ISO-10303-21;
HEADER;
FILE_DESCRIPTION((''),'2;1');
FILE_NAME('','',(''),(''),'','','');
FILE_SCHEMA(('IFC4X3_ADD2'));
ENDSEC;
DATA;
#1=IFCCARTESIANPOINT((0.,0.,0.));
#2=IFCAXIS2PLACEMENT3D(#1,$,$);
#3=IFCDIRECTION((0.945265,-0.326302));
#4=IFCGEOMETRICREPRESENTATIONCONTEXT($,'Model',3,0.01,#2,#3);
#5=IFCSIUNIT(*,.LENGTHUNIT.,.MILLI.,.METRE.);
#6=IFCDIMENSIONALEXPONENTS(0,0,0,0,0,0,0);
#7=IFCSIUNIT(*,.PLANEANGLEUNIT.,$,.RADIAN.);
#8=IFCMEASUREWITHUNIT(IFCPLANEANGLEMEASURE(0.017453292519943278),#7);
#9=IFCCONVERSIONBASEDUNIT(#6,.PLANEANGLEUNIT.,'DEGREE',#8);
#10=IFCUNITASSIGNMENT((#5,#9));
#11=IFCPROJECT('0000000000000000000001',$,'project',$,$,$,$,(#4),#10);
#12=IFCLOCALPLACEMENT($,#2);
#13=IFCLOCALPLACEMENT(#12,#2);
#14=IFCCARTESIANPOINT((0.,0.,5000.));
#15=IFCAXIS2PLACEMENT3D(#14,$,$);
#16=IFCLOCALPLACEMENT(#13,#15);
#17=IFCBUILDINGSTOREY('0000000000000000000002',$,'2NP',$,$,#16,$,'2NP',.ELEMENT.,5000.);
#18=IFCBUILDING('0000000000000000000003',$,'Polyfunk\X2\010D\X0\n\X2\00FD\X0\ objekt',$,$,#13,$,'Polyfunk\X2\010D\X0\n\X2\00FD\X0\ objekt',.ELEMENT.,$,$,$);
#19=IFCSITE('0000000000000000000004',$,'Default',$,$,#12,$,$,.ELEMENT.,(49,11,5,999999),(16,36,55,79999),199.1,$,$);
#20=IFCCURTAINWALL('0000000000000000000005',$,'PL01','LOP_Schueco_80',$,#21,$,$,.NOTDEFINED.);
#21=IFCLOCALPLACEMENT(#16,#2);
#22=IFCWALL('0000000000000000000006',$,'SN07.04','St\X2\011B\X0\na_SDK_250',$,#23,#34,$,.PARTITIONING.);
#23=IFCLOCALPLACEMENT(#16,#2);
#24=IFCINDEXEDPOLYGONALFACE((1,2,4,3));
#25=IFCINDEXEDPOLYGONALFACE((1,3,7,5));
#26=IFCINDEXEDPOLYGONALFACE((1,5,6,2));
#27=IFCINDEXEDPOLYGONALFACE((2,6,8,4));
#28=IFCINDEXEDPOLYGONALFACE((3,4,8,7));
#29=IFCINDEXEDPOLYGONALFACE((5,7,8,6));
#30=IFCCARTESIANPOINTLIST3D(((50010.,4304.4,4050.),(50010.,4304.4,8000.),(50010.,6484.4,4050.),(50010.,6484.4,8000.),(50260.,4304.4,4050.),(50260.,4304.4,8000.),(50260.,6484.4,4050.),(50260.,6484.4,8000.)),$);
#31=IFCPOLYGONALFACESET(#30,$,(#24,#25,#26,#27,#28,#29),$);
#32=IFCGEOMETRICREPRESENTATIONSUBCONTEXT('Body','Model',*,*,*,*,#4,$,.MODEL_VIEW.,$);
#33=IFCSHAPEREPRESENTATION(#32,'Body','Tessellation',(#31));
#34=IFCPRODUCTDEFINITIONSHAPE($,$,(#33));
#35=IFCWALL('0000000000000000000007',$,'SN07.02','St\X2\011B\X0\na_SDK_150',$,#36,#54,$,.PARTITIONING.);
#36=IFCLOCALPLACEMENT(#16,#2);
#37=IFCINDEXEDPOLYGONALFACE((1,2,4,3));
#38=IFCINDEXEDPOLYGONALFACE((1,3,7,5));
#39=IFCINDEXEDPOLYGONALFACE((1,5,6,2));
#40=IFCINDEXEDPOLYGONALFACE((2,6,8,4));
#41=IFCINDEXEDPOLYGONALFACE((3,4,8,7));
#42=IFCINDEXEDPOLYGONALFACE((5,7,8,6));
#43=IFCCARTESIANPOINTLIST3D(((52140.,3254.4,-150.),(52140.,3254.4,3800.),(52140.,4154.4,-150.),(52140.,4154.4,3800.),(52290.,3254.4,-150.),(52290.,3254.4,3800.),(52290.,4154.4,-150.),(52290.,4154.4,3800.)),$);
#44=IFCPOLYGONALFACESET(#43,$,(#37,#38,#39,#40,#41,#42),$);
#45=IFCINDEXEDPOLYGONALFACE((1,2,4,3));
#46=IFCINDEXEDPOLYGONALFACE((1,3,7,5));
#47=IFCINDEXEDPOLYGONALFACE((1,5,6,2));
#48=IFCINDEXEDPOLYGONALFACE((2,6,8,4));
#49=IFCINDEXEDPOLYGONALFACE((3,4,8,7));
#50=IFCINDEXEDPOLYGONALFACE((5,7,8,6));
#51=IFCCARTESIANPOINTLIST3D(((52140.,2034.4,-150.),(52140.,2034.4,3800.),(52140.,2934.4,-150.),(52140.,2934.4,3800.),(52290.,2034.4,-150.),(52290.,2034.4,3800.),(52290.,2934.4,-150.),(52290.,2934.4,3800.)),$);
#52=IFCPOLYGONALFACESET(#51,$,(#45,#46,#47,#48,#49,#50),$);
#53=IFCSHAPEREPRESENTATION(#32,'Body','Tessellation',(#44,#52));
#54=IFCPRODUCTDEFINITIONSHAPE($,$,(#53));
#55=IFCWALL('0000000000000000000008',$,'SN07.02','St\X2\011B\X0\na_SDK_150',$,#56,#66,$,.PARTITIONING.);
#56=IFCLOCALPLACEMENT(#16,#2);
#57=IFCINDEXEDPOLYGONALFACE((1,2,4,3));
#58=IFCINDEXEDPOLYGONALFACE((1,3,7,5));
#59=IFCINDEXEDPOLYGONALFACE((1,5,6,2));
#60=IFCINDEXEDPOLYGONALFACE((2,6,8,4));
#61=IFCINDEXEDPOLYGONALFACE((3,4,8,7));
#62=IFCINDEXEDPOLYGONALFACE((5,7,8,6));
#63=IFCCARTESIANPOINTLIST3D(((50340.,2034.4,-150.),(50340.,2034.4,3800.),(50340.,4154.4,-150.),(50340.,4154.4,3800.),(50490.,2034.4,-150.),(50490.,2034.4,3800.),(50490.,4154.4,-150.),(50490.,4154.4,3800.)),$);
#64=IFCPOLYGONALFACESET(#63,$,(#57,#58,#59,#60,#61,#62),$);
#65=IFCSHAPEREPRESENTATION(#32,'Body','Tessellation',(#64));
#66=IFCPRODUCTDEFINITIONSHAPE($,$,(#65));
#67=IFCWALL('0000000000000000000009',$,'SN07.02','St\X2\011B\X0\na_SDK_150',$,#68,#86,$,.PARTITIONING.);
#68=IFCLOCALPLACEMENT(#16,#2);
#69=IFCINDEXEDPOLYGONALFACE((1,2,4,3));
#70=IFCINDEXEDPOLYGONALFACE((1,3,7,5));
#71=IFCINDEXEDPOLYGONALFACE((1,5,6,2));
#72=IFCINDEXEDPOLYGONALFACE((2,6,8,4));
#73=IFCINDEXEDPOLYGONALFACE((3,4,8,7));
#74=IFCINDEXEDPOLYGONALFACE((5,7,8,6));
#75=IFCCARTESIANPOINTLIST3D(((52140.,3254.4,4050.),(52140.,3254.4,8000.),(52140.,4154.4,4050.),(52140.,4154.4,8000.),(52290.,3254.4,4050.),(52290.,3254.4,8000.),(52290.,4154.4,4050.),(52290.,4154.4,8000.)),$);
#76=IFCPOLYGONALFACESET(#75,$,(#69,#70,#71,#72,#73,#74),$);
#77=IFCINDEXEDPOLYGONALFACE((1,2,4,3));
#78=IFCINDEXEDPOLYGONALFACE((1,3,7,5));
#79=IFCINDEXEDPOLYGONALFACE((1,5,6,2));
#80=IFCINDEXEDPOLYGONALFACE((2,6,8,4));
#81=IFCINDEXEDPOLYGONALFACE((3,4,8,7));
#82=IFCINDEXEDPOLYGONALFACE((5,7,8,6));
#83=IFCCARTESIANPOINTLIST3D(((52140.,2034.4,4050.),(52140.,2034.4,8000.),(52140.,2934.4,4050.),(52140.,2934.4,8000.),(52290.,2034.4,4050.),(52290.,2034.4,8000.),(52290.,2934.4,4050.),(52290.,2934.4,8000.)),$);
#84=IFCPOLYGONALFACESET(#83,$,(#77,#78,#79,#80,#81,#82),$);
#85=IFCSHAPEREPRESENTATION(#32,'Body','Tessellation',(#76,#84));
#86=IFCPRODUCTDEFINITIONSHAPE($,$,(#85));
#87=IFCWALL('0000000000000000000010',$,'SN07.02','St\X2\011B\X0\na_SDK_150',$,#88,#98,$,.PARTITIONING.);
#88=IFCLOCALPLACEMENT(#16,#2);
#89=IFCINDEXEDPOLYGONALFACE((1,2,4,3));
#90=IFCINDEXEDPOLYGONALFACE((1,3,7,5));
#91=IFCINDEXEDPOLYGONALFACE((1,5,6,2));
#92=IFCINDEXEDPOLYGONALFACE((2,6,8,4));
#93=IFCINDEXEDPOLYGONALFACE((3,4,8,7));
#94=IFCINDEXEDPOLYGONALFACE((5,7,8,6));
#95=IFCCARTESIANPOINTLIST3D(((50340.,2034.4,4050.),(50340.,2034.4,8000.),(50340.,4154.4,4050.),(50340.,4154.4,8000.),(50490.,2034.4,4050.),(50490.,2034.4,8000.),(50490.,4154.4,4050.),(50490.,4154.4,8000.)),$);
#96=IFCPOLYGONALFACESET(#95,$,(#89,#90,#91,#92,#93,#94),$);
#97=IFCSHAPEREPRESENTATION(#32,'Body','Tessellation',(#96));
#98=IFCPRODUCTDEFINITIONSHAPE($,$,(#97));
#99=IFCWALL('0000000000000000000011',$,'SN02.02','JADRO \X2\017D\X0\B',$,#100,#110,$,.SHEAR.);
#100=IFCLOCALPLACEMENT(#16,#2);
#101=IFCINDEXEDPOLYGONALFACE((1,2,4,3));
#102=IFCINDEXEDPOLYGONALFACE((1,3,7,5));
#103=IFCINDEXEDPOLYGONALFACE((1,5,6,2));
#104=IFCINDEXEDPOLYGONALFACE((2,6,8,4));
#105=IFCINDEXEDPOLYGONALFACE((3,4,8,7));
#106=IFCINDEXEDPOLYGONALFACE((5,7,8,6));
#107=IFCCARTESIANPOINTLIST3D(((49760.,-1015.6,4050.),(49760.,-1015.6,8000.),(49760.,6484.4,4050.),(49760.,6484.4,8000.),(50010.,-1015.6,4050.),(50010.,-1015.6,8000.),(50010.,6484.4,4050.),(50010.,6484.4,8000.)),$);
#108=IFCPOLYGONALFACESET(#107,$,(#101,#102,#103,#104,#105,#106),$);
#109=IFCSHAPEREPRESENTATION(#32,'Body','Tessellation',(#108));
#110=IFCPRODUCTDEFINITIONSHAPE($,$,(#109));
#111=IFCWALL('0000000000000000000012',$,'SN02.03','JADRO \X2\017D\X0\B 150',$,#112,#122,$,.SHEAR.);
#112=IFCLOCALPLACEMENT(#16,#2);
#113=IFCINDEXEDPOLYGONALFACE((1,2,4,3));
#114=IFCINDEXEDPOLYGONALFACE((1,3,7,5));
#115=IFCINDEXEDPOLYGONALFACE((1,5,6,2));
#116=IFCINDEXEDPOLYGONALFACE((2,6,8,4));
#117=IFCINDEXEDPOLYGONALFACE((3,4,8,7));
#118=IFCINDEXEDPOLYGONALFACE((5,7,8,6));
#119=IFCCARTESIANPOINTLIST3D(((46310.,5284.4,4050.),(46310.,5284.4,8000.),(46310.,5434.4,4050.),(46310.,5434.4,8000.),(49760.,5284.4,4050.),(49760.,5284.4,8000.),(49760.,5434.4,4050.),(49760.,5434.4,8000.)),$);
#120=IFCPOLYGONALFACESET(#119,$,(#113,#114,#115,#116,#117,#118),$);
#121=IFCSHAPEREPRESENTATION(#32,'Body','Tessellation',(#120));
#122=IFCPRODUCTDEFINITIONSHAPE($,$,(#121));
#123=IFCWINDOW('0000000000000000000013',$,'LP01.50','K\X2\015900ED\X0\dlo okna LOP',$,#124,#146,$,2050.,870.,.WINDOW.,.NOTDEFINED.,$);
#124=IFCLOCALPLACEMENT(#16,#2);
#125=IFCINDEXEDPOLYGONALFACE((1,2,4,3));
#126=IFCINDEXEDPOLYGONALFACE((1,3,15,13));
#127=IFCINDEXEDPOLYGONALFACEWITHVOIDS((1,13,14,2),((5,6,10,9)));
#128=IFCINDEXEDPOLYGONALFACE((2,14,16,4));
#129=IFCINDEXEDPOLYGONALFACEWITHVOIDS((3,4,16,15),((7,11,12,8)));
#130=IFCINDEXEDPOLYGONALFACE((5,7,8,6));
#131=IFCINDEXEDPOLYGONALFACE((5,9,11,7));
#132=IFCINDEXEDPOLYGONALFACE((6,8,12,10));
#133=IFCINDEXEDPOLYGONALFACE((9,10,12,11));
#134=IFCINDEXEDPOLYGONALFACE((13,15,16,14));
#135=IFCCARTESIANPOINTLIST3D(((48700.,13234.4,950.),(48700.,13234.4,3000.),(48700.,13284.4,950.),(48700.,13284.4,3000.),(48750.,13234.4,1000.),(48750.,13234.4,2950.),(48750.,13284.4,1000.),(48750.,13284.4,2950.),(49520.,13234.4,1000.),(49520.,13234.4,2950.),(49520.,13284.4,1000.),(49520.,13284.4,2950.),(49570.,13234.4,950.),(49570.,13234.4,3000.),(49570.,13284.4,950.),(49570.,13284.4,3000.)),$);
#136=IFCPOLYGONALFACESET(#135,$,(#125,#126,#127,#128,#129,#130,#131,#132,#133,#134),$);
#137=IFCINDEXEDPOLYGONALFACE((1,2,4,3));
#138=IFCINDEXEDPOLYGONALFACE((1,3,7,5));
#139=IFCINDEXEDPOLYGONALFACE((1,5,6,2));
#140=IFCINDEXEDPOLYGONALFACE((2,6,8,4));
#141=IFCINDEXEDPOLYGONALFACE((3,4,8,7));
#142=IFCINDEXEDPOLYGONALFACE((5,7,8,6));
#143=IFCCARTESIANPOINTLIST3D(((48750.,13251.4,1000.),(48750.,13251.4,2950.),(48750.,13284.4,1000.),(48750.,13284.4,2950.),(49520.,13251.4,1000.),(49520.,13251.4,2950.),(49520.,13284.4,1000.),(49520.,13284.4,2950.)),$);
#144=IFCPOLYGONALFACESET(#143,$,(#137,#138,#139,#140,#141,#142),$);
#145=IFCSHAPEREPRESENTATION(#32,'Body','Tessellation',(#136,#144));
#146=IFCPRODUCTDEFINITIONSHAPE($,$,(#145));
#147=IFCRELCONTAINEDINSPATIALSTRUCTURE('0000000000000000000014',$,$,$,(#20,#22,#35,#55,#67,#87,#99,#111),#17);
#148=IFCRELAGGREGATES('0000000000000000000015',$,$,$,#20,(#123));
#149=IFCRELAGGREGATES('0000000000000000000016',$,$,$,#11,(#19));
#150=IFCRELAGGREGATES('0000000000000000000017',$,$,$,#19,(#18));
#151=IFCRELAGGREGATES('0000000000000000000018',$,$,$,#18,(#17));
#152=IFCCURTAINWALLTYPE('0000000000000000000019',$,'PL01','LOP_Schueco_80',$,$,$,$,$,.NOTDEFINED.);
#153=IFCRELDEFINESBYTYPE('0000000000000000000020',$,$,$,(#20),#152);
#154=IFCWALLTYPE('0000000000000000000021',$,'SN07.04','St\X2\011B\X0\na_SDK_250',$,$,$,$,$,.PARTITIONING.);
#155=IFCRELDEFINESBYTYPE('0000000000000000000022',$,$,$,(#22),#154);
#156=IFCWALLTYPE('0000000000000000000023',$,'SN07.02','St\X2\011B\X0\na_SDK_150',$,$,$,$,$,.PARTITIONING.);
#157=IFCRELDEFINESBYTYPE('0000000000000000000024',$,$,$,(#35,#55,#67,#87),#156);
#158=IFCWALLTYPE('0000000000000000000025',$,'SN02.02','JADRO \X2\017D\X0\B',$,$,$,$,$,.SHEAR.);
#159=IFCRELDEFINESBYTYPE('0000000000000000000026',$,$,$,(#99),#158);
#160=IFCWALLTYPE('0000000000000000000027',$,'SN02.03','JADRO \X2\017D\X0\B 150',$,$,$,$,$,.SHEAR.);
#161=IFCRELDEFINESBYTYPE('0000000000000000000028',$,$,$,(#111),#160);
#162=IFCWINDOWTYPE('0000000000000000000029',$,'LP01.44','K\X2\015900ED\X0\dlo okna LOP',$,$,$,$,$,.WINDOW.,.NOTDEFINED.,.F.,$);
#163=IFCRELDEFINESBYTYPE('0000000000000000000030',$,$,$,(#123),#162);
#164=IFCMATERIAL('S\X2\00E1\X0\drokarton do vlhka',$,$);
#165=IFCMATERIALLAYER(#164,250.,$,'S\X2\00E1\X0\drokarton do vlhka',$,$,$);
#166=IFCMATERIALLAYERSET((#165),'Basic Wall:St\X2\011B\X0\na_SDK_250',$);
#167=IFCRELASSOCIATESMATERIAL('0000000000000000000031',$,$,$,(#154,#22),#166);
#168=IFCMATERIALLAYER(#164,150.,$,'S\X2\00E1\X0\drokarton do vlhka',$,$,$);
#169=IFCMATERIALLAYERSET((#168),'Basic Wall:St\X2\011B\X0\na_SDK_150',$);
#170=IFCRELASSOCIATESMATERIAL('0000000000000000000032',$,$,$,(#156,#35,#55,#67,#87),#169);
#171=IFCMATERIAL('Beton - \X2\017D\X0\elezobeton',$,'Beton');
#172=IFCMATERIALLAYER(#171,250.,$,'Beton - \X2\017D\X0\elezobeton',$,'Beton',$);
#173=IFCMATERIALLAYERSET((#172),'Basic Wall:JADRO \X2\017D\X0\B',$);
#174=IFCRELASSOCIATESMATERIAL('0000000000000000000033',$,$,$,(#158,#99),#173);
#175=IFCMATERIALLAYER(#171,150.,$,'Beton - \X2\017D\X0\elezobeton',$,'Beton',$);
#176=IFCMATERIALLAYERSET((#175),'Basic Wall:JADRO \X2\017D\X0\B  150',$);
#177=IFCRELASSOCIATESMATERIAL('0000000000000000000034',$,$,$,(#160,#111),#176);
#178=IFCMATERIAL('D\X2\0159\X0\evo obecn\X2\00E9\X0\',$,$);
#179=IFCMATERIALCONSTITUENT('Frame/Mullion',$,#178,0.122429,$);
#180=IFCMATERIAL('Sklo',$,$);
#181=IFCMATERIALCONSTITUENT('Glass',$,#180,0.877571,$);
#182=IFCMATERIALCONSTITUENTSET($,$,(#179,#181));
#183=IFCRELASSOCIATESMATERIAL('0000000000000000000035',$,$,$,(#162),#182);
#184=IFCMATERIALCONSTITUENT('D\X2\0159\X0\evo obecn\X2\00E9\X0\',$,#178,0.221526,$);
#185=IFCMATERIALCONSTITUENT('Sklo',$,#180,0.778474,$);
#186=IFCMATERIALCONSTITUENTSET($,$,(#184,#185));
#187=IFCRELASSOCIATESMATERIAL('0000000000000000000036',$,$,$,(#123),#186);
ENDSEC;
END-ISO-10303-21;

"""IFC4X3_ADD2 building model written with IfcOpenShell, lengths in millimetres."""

from ifc_helpers import new_model, entity, si_unit, converted_unit, direction, frame, frame_2d, origin, origin_2d_with_axis, place, context, subcontext, project, spatial, polyline, rectangle, outline, extrude, clip, bounded_halfspace, source, transform, mapped, material, layer, layer_set, constituent, constituent_set, type_object, type_shapes, element, aggregate, save


model = new_model("IFC4X3_ADD2")

# Units and contexts
model_context = context("Model", 3, precision=0.01, world=origin(), true_north=direction((0.945265, -0.326302)))
body_context = subcontext(model_context, "Body", "Model", "MODEL_VIEW")
ifc_project = project(units=[si_unit("LENGTHUNIT", "METRE", prefix="MILLI"), converted_unit("PLANEANGLEUNIT", "DEGREE", entity("IfcPlaneAngleMeasure", 0.017453292519943278), si_unit("PLANEANGLEUNIT", "RADIAN"), dimensions=[0, 0, 0, 0, 0, 0, 0])], contexts=[model_context])

# Site, building, storey
site_placement = place(None, origin())
site = spatial("IfcSite", under=ifc_project, at=site_placement, Name="Default", CompositionType="ELEMENT", RefLatitude=(49, 11, 5, 999999), RefLongitude=(16, 36, 55, 79999), RefElevation=199.1)
building_placement = place(site_placement, origin())
building = spatial("IfcBuilding", under=site, at=building_placement, Name="Polyfunkčný objekt", LongName="Polyfunkčný objekt", CompositionType="ELEMENT")
storey_placement = place(building_placement, frame((0.0, 0.0, 5000.0)))
storey = spatial("IfcBuildingStorey", under=building, at=storey_placement, Name="2NP", LongName="2NP", CompositionType="ELEMENT", Elevation=5000.0)

# Curtain wall
curtain_wall_type = type_object("IfcCurtainWallType", Name="PL01", Description="LOP_Schueco_80", PredefinedType="NOTDEFINED")
curtain_wall_placement = place(storey_placement, frame((0.0, 0.0, -5000.0)))
curtain_wall = element("IfcCurtainWall", 1, at=curtain_wall_placement, inside=storey, type_object=curtain_wall_type, Name="PL01", Description="LOP_Schueco_80", PredefinedType="NOTDEFINED")
ifc_material_1 = material(Name="Sklo")

# Walls
ifc_material_2 = material(Name="Sádrokarton do vlhka")
ifc_layer_1 = layer(ifc_material_2, 250.0, Name="Sádrokarton do vlhka")
ifc_layer_set_1 = layer_set([ifc_layer_1], Name="Basic Wall:Stěna_SDK_250")
wall_type_1 = type_object("IfcWallType", Name="SN07.04", Description="Stěna_SDK_250", PredefinedType="PARTITIONING", material=ifc_layer_set_1)
wall_1_placement = place(storey_placement, frame((50135.0, 6484.4, 4050.0), z_axis=(0.0, 0.0, 1.0), x_axis=(0.0, -1.0, 0.0)))
element("IfcWall", 2, at=wall_1_placement, inside=storey, type_object=wall_type_1, material=ifc_layer_set_1, Name="SN07.04", Description="Stěna_SDK_250", PredefinedType="PARTITIONING", context=body_context, shape_type="Clipping", body=[
    clip(clip(extrude(rectangle(XDim=2180.0, YDim=250.0, at=frame_2d((1090.0, 0.0), x_axis=(-1.0, 0.0))), origin(), (0.0, 0.0, 1.0), 3950.0), bounded_halfspace(frame((2180.0, -125.0, 0.0), z_axis=(0.0, 0.0, 1.0), x_axis=(0.0, -1.0, 0.0)), True, frame((2180.0, -125.0, 0.0)), polyline([(0.0, 0.0), (0.0, 250.0), (-1930.0, 250.0), (-2180.0, 250.0), (-2180.0, 0.0), (0.0, 0.0)]))), bounded_halfspace(frame((0.0, -125.0, 3950.0), z_axis=(0.0, 0.0, -1.0), x_axis=(0.0, 1.0, 0.0)), True, frame((0.0, -125.0, 3950.0)), polyline([(0.0, 0.0), (2180.0, 0.0), (2180.0, 250.0), (250.0, 250.0), (0.0, 250.0), (0.0, 0.0)]))),
])
ifc_layer_2 = layer(ifc_material_2, 150.0, Name="Sádrokarton do vlhka")
ifc_layer_set_2 = layer_set([ifc_layer_2], Name="Basic Wall:Stěna_SDK_150")
wall_type_2 = type_object("IfcWallType", Name="SN07.02", Description="Stěna_SDK_150", PredefinedType="PARTITIONING", material=ifc_layer_set_2)
wall_2_placement = place(storey_placement, frame((52215.0, 4154.4, -150.0), z_axis=(0.0, 0.0, 1.0), x_axis=(0.0, -1.0, 0.0)))
element("IfcWall", 3, at=wall_2_placement, inside=storey, type_object=wall_type_2, material=ifc_layer_set_2, Name="SN07.02", Description="Stěna_SDK_150", PredefinedType="PARTITIONING", context=body_context, shape_type="SweptSolid", body=[
    extrude(rectangle(XDim=900.0, YDim=150.0, at=frame_2d((0.0, 0.0), x_axis=(1.0, 0.0))), frame((450.0, 0.0, 0.0)), (0.0, 0.0, 1.0), 3950.0),
    extrude(rectangle(XDim=900.0, YDim=150.0, at=frame_2d((0.0, 0.0), x_axis=(1.0, 0.0))), frame((1670.0, 0.0, 0.0), z_axis=(0.0, 0.0, 1.0), x_axis=(-1.0, 0.0, 0.0)), (0.0, 0.0, 1.0), 3950.0),
])
wall_3_placement = place(storey_placement, frame((50415.0, 4154.4, -150.0), z_axis=(0.0, 0.0, 1.0), x_axis=(0.0, -1.0, 0.0)))
element("IfcWall", 4, at=wall_3_placement, inside=storey, type_object=wall_type_2, material=ifc_layer_set_2, Name="SN07.02", Description="Stěna_SDK_150", PredefinedType="PARTITIONING", context=body_context, shape_type="Clipping", body=[
    clip(clip(extrude(rectangle(XDim=2120.0, YDim=150.0, at=frame_2d((1060.0, 0.0), x_axis=(-1.0, 0.0))), origin(), (0.0, 0.0, 1.0), 3950.0), bounded_halfspace(frame((2120.0, -75.0, 0.0), z_axis=(0.0, 0.0, 1.0), x_axis=(0.0, -1.0, 0.0)), True, frame((2120.0, -75.0, 0.0)), polyline([(0.0, 0.0), (0.0, 150.0), (-900.0, 150.0), (-1220.0, 150.0), (-2120.0, 150.0), (-2120.0, 0.0), (0.0, 0.0)]))), bounded_halfspace(frame((0.0, -75.0, 3950.0), z_axis=(0.0, 0.0, -1.0), x_axis=(0.0, 1.0, 0.0)), True, frame((0.0, -75.0, 3950.0)), polyline([(0.0, 0.0), (2120.0, 0.0), (2120.0, 150.0), (1220.0, 150.0), (900.0, 150.0), (0.0, 150.0), (0.0, 0.0)]))),
])
wall_4_placement = place(storey_placement, frame((52215.0, 4154.4, 4050.0), z_axis=(0.0, 0.0, 1.0), x_axis=(0.0, -1.0, 0.0)))
element("IfcWall", 5, at=wall_4_placement, inside=storey, type_object=wall_type_2, material=ifc_layer_set_2, Name="SN07.02", Description="Stěna_SDK_150", PredefinedType="PARTITIONING", context=body_context, shape_type="SweptSolid", body=[
    extrude(rectangle(XDim=900.0, YDim=150.0, at=frame_2d((0.0, 0.0), x_axis=(1.0, 0.0))), frame((450.0, 0.0, 0.0)), (0.0, 0.0, 1.0), 3950.0),
    extrude(rectangle(XDim=900.0, YDim=150.0, at=frame_2d((0.0, 0.0), x_axis=(1.0, 0.0))), frame((1670.0, 0.0, 0.0), z_axis=(0.0, 0.0, 1.0), x_axis=(-1.0, 0.0, 0.0)), (0.0, 0.0, 1.0), 3950.0),
])
wall_5_placement = place(storey_placement, frame((50415.0, 4154.4, 4050.0), z_axis=(0.0, 0.0, 1.0), x_axis=(0.0, -1.0, 0.0)))
element("IfcWall", 6, at=wall_5_placement, inside=storey, type_object=wall_type_2, material=ifc_layer_set_2, Name="SN07.02", Description="Stěna_SDK_150", PredefinedType="PARTITIONING", context=body_context, shape_type="Clipping", body=[
    clip(clip(extrude(rectangle(XDim=2120.0, YDim=150.0, at=frame_2d((1060.0, 0.0), x_axis=(-1.0, 0.0))), origin(), (0.0, 0.0, 1.0), 3950.0), bounded_halfspace(frame((2120.0, -75.0, 0.0), z_axis=(0.0, 0.0, 1.0), x_axis=(0.0, -1.0, 0.0)), True, frame((2120.0, -75.0, 0.0)), polyline([(0.0, 0.0), (0.0, 150.0), (-900.0, 150.0), (-1220.0, 150.0), (-2120.0, 150.0), (-2120.0, 0.0), (0.0, 0.0)]))), bounded_halfspace(frame((0.0, -75.0, 3950.0), z_axis=(0.0, 0.0, -1.0), x_axis=(0.0, 1.0, 0.0)), True, frame((0.0, -75.0, 3950.0)), polyline([(0.0, 0.0), (2120.0, 0.0), (2120.0, 150.0), (1220.0, 150.0), (900.0, 150.0), (0.0, 150.0), (0.0, 0.0)]))),
])
ifc_material_3 = material(Name="Beton - Železobeton", Category="Beton")
ifc_layer_3 = layer(ifc_material_3, 250.0, Name="Beton - Železobeton", Category="Beton")
ifc_layer_set_3 = layer_set([ifc_layer_3], Name="Basic Wall:JADRO ŽB")
wall_type_3 = type_object("IfcWallType", Name="SN02.02", Description="JADRO ŽB", PredefinedType="SHEAR", material=ifc_layer_set_3)
wall_6_placement = place(storey_placement, frame((49885.0, 6484.4, 4050.0), z_axis=(0.0, 0.0, 1.0), x_axis=(0.0, -1.0, 0.0)))
element("IfcWall", 7, at=wall_6_placement, inside=storey, type_object=wall_type_3, material=ifc_layer_set_3, Name="SN02.02", Description="JADRO ŽB", PredefinedType="SHEAR", context=body_context, shape_type="Clipping", body=[
    clip(clip(extrude(rectangle(XDim=7500.0, YDim=250.0, at=frame_2d((3750.0, 0.0), x_axis=(-1.0, 0.0))), origin(), (0.0, 0.0, 1.0), 3950.0), bounded_halfspace(frame((7500.0, -125.0, 0.0), z_axis=(0.0, 0.0, 1.0), x_axis=(0.0, -1.0, 0.0)), True, frame((7500.0, -125.0, 0.0)), polyline([(0.0, 0.0), (0.0, 250.0), (-7500.0, 250.0), (-7500.0, 0.0), (-7250.0, 0.0), (-6450.0, 0.0), (-6300.0, 0.0), (0.0, 0.0)]))), bounded_halfspace(frame((0.0, -125.0, 3950.0), z_axis=(0.0, 0.0, -1.0), x_axis=(0.0, 1.0, 0.0)), True, frame((0.0, -125.0, 3950.0)), polyline([(0.0, 0.0), (250.0, 0.0), (1050.0, 0.0), (1200.0, 0.0), (7500.0, 0.0), (7500.0, 250.0), (0.0, 250.0), (0.0, 0.0)]))),
])
ifc_layer_4 = layer(ifc_material_3, 150.0, Name="Beton - Železobeton", Category="Beton")
ifc_layer_set_4 = layer_set([ifc_layer_4], Name="Basic Wall:JADRO ŽB  150")
wall_type_4 = type_object("IfcWallType", Name="SN02.03", Description="JADRO ŽB 150", PredefinedType="SHEAR", material=ifc_layer_set_4)
wall_7_placement = place(storey_placement, frame((46310.0, 5359.4, 4050.0)))
element("IfcWall", 8, at=wall_7_placement, inside=storey, type_object=wall_type_4, material=ifc_layer_set_4, Name="SN02.03", Description="JADRO ŽB 150", PredefinedType="SHEAR", context=body_context, shape_type="SweptSolid", body=[
    extrude(rectangle(XDim=3450.0, YDim=150.0, at=frame_2d((1725.0, 0.0), x_axis=(-1.0, 0.0))), origin(), (0.0, 0.0, 1.0), 3950.0),
])

# Window
ifc_material_4 = material(Name="Dřevo obecné")
ifc_constituent_1 = constituent(ifc_material_4, Name="Dřevo obecné", fraction=0.221526)
ifc_constituent_2 = constituent(ifc_material_1, Name="Sklo", fraction=0.778474)
ifc_constituent_set_1 = constituent_set(constituents=[ifc_constituent_1, ifc_constituent_2])
ifc_constituent_3 = constituent(ifc_material_4, Name="Frame/Mullion", fraction=0.122429)
ifc_constituent_4 = constituent(ifc_material_1, Name="Glass", fraction=0.877571)
ifc_constituent_set_2 = constituent_set(constituents=[ifc_constituent_3, ifc_constituent_4])
window_type = type_object("IfcWindowType", Name="LP01.44", Description="Křídlo okna LOP", ParameterTakesPrecedence=False, PartitioningType="NOTDEFINED", PredefinedType="WINDOW", material=ifc_constituent_set_2)
shared_shape_1 = source(origin(), body_context, "Body", "SweptSolid", [
    extrude(outline(polyline([(-1025.0, -435.0), (1025.0, -435.0), (1025.0, 435.0), (-1025.0, 435.0), (-1025.0, -435.0)]), holes=[polyline([(-975.0, -385.0), (-975.0, 385.0), (975.0, 385.0), (975.0, -385.0), (-975.0, -385.0)])]), frame((0.0, 0.0, 1025.0), z_axis=(0.0, 1.0, 0.0), x_axis=(0.0, 0.0, -1.0)), (0.0, 0.0, 1.0), 50.0),
    extrude(rectangle(XDim=33.0, YDim=770.0, at=origin_2d_with_axis()), frame((0.0, 33.5, 50.0), z_axis=(0.0, 0.0, 1.0), x_axis=(0.0, -1.0, 0.0)), (0.0, 0.0, 1.0), 1950.0),
])
type_shapes(window_type, [shared_shape_1])
window_placement = place(curtain_wall_placement, frame((49135.0, 13234.4, 5950.0)))
window = element("IfcWindow", 9, at=window_placement, type_object=window_type, material=ifc_constituent_set_1, Name="LP01.50", Description="Křídlo okna LOP", OverallHeight=2050.0, OverallWidth=870.0, PartitioningType="NOTDEFINED", PredefinedType="WINDOW", context=body_context, shape_type="MappedRepresentation", body=[
    mapped(shared_shape_1, transform((0.0, 0.0, 0.0), scale=1.0)),
])
aggregate(curtain_wall, [window])

save(model, "model.ifc")
